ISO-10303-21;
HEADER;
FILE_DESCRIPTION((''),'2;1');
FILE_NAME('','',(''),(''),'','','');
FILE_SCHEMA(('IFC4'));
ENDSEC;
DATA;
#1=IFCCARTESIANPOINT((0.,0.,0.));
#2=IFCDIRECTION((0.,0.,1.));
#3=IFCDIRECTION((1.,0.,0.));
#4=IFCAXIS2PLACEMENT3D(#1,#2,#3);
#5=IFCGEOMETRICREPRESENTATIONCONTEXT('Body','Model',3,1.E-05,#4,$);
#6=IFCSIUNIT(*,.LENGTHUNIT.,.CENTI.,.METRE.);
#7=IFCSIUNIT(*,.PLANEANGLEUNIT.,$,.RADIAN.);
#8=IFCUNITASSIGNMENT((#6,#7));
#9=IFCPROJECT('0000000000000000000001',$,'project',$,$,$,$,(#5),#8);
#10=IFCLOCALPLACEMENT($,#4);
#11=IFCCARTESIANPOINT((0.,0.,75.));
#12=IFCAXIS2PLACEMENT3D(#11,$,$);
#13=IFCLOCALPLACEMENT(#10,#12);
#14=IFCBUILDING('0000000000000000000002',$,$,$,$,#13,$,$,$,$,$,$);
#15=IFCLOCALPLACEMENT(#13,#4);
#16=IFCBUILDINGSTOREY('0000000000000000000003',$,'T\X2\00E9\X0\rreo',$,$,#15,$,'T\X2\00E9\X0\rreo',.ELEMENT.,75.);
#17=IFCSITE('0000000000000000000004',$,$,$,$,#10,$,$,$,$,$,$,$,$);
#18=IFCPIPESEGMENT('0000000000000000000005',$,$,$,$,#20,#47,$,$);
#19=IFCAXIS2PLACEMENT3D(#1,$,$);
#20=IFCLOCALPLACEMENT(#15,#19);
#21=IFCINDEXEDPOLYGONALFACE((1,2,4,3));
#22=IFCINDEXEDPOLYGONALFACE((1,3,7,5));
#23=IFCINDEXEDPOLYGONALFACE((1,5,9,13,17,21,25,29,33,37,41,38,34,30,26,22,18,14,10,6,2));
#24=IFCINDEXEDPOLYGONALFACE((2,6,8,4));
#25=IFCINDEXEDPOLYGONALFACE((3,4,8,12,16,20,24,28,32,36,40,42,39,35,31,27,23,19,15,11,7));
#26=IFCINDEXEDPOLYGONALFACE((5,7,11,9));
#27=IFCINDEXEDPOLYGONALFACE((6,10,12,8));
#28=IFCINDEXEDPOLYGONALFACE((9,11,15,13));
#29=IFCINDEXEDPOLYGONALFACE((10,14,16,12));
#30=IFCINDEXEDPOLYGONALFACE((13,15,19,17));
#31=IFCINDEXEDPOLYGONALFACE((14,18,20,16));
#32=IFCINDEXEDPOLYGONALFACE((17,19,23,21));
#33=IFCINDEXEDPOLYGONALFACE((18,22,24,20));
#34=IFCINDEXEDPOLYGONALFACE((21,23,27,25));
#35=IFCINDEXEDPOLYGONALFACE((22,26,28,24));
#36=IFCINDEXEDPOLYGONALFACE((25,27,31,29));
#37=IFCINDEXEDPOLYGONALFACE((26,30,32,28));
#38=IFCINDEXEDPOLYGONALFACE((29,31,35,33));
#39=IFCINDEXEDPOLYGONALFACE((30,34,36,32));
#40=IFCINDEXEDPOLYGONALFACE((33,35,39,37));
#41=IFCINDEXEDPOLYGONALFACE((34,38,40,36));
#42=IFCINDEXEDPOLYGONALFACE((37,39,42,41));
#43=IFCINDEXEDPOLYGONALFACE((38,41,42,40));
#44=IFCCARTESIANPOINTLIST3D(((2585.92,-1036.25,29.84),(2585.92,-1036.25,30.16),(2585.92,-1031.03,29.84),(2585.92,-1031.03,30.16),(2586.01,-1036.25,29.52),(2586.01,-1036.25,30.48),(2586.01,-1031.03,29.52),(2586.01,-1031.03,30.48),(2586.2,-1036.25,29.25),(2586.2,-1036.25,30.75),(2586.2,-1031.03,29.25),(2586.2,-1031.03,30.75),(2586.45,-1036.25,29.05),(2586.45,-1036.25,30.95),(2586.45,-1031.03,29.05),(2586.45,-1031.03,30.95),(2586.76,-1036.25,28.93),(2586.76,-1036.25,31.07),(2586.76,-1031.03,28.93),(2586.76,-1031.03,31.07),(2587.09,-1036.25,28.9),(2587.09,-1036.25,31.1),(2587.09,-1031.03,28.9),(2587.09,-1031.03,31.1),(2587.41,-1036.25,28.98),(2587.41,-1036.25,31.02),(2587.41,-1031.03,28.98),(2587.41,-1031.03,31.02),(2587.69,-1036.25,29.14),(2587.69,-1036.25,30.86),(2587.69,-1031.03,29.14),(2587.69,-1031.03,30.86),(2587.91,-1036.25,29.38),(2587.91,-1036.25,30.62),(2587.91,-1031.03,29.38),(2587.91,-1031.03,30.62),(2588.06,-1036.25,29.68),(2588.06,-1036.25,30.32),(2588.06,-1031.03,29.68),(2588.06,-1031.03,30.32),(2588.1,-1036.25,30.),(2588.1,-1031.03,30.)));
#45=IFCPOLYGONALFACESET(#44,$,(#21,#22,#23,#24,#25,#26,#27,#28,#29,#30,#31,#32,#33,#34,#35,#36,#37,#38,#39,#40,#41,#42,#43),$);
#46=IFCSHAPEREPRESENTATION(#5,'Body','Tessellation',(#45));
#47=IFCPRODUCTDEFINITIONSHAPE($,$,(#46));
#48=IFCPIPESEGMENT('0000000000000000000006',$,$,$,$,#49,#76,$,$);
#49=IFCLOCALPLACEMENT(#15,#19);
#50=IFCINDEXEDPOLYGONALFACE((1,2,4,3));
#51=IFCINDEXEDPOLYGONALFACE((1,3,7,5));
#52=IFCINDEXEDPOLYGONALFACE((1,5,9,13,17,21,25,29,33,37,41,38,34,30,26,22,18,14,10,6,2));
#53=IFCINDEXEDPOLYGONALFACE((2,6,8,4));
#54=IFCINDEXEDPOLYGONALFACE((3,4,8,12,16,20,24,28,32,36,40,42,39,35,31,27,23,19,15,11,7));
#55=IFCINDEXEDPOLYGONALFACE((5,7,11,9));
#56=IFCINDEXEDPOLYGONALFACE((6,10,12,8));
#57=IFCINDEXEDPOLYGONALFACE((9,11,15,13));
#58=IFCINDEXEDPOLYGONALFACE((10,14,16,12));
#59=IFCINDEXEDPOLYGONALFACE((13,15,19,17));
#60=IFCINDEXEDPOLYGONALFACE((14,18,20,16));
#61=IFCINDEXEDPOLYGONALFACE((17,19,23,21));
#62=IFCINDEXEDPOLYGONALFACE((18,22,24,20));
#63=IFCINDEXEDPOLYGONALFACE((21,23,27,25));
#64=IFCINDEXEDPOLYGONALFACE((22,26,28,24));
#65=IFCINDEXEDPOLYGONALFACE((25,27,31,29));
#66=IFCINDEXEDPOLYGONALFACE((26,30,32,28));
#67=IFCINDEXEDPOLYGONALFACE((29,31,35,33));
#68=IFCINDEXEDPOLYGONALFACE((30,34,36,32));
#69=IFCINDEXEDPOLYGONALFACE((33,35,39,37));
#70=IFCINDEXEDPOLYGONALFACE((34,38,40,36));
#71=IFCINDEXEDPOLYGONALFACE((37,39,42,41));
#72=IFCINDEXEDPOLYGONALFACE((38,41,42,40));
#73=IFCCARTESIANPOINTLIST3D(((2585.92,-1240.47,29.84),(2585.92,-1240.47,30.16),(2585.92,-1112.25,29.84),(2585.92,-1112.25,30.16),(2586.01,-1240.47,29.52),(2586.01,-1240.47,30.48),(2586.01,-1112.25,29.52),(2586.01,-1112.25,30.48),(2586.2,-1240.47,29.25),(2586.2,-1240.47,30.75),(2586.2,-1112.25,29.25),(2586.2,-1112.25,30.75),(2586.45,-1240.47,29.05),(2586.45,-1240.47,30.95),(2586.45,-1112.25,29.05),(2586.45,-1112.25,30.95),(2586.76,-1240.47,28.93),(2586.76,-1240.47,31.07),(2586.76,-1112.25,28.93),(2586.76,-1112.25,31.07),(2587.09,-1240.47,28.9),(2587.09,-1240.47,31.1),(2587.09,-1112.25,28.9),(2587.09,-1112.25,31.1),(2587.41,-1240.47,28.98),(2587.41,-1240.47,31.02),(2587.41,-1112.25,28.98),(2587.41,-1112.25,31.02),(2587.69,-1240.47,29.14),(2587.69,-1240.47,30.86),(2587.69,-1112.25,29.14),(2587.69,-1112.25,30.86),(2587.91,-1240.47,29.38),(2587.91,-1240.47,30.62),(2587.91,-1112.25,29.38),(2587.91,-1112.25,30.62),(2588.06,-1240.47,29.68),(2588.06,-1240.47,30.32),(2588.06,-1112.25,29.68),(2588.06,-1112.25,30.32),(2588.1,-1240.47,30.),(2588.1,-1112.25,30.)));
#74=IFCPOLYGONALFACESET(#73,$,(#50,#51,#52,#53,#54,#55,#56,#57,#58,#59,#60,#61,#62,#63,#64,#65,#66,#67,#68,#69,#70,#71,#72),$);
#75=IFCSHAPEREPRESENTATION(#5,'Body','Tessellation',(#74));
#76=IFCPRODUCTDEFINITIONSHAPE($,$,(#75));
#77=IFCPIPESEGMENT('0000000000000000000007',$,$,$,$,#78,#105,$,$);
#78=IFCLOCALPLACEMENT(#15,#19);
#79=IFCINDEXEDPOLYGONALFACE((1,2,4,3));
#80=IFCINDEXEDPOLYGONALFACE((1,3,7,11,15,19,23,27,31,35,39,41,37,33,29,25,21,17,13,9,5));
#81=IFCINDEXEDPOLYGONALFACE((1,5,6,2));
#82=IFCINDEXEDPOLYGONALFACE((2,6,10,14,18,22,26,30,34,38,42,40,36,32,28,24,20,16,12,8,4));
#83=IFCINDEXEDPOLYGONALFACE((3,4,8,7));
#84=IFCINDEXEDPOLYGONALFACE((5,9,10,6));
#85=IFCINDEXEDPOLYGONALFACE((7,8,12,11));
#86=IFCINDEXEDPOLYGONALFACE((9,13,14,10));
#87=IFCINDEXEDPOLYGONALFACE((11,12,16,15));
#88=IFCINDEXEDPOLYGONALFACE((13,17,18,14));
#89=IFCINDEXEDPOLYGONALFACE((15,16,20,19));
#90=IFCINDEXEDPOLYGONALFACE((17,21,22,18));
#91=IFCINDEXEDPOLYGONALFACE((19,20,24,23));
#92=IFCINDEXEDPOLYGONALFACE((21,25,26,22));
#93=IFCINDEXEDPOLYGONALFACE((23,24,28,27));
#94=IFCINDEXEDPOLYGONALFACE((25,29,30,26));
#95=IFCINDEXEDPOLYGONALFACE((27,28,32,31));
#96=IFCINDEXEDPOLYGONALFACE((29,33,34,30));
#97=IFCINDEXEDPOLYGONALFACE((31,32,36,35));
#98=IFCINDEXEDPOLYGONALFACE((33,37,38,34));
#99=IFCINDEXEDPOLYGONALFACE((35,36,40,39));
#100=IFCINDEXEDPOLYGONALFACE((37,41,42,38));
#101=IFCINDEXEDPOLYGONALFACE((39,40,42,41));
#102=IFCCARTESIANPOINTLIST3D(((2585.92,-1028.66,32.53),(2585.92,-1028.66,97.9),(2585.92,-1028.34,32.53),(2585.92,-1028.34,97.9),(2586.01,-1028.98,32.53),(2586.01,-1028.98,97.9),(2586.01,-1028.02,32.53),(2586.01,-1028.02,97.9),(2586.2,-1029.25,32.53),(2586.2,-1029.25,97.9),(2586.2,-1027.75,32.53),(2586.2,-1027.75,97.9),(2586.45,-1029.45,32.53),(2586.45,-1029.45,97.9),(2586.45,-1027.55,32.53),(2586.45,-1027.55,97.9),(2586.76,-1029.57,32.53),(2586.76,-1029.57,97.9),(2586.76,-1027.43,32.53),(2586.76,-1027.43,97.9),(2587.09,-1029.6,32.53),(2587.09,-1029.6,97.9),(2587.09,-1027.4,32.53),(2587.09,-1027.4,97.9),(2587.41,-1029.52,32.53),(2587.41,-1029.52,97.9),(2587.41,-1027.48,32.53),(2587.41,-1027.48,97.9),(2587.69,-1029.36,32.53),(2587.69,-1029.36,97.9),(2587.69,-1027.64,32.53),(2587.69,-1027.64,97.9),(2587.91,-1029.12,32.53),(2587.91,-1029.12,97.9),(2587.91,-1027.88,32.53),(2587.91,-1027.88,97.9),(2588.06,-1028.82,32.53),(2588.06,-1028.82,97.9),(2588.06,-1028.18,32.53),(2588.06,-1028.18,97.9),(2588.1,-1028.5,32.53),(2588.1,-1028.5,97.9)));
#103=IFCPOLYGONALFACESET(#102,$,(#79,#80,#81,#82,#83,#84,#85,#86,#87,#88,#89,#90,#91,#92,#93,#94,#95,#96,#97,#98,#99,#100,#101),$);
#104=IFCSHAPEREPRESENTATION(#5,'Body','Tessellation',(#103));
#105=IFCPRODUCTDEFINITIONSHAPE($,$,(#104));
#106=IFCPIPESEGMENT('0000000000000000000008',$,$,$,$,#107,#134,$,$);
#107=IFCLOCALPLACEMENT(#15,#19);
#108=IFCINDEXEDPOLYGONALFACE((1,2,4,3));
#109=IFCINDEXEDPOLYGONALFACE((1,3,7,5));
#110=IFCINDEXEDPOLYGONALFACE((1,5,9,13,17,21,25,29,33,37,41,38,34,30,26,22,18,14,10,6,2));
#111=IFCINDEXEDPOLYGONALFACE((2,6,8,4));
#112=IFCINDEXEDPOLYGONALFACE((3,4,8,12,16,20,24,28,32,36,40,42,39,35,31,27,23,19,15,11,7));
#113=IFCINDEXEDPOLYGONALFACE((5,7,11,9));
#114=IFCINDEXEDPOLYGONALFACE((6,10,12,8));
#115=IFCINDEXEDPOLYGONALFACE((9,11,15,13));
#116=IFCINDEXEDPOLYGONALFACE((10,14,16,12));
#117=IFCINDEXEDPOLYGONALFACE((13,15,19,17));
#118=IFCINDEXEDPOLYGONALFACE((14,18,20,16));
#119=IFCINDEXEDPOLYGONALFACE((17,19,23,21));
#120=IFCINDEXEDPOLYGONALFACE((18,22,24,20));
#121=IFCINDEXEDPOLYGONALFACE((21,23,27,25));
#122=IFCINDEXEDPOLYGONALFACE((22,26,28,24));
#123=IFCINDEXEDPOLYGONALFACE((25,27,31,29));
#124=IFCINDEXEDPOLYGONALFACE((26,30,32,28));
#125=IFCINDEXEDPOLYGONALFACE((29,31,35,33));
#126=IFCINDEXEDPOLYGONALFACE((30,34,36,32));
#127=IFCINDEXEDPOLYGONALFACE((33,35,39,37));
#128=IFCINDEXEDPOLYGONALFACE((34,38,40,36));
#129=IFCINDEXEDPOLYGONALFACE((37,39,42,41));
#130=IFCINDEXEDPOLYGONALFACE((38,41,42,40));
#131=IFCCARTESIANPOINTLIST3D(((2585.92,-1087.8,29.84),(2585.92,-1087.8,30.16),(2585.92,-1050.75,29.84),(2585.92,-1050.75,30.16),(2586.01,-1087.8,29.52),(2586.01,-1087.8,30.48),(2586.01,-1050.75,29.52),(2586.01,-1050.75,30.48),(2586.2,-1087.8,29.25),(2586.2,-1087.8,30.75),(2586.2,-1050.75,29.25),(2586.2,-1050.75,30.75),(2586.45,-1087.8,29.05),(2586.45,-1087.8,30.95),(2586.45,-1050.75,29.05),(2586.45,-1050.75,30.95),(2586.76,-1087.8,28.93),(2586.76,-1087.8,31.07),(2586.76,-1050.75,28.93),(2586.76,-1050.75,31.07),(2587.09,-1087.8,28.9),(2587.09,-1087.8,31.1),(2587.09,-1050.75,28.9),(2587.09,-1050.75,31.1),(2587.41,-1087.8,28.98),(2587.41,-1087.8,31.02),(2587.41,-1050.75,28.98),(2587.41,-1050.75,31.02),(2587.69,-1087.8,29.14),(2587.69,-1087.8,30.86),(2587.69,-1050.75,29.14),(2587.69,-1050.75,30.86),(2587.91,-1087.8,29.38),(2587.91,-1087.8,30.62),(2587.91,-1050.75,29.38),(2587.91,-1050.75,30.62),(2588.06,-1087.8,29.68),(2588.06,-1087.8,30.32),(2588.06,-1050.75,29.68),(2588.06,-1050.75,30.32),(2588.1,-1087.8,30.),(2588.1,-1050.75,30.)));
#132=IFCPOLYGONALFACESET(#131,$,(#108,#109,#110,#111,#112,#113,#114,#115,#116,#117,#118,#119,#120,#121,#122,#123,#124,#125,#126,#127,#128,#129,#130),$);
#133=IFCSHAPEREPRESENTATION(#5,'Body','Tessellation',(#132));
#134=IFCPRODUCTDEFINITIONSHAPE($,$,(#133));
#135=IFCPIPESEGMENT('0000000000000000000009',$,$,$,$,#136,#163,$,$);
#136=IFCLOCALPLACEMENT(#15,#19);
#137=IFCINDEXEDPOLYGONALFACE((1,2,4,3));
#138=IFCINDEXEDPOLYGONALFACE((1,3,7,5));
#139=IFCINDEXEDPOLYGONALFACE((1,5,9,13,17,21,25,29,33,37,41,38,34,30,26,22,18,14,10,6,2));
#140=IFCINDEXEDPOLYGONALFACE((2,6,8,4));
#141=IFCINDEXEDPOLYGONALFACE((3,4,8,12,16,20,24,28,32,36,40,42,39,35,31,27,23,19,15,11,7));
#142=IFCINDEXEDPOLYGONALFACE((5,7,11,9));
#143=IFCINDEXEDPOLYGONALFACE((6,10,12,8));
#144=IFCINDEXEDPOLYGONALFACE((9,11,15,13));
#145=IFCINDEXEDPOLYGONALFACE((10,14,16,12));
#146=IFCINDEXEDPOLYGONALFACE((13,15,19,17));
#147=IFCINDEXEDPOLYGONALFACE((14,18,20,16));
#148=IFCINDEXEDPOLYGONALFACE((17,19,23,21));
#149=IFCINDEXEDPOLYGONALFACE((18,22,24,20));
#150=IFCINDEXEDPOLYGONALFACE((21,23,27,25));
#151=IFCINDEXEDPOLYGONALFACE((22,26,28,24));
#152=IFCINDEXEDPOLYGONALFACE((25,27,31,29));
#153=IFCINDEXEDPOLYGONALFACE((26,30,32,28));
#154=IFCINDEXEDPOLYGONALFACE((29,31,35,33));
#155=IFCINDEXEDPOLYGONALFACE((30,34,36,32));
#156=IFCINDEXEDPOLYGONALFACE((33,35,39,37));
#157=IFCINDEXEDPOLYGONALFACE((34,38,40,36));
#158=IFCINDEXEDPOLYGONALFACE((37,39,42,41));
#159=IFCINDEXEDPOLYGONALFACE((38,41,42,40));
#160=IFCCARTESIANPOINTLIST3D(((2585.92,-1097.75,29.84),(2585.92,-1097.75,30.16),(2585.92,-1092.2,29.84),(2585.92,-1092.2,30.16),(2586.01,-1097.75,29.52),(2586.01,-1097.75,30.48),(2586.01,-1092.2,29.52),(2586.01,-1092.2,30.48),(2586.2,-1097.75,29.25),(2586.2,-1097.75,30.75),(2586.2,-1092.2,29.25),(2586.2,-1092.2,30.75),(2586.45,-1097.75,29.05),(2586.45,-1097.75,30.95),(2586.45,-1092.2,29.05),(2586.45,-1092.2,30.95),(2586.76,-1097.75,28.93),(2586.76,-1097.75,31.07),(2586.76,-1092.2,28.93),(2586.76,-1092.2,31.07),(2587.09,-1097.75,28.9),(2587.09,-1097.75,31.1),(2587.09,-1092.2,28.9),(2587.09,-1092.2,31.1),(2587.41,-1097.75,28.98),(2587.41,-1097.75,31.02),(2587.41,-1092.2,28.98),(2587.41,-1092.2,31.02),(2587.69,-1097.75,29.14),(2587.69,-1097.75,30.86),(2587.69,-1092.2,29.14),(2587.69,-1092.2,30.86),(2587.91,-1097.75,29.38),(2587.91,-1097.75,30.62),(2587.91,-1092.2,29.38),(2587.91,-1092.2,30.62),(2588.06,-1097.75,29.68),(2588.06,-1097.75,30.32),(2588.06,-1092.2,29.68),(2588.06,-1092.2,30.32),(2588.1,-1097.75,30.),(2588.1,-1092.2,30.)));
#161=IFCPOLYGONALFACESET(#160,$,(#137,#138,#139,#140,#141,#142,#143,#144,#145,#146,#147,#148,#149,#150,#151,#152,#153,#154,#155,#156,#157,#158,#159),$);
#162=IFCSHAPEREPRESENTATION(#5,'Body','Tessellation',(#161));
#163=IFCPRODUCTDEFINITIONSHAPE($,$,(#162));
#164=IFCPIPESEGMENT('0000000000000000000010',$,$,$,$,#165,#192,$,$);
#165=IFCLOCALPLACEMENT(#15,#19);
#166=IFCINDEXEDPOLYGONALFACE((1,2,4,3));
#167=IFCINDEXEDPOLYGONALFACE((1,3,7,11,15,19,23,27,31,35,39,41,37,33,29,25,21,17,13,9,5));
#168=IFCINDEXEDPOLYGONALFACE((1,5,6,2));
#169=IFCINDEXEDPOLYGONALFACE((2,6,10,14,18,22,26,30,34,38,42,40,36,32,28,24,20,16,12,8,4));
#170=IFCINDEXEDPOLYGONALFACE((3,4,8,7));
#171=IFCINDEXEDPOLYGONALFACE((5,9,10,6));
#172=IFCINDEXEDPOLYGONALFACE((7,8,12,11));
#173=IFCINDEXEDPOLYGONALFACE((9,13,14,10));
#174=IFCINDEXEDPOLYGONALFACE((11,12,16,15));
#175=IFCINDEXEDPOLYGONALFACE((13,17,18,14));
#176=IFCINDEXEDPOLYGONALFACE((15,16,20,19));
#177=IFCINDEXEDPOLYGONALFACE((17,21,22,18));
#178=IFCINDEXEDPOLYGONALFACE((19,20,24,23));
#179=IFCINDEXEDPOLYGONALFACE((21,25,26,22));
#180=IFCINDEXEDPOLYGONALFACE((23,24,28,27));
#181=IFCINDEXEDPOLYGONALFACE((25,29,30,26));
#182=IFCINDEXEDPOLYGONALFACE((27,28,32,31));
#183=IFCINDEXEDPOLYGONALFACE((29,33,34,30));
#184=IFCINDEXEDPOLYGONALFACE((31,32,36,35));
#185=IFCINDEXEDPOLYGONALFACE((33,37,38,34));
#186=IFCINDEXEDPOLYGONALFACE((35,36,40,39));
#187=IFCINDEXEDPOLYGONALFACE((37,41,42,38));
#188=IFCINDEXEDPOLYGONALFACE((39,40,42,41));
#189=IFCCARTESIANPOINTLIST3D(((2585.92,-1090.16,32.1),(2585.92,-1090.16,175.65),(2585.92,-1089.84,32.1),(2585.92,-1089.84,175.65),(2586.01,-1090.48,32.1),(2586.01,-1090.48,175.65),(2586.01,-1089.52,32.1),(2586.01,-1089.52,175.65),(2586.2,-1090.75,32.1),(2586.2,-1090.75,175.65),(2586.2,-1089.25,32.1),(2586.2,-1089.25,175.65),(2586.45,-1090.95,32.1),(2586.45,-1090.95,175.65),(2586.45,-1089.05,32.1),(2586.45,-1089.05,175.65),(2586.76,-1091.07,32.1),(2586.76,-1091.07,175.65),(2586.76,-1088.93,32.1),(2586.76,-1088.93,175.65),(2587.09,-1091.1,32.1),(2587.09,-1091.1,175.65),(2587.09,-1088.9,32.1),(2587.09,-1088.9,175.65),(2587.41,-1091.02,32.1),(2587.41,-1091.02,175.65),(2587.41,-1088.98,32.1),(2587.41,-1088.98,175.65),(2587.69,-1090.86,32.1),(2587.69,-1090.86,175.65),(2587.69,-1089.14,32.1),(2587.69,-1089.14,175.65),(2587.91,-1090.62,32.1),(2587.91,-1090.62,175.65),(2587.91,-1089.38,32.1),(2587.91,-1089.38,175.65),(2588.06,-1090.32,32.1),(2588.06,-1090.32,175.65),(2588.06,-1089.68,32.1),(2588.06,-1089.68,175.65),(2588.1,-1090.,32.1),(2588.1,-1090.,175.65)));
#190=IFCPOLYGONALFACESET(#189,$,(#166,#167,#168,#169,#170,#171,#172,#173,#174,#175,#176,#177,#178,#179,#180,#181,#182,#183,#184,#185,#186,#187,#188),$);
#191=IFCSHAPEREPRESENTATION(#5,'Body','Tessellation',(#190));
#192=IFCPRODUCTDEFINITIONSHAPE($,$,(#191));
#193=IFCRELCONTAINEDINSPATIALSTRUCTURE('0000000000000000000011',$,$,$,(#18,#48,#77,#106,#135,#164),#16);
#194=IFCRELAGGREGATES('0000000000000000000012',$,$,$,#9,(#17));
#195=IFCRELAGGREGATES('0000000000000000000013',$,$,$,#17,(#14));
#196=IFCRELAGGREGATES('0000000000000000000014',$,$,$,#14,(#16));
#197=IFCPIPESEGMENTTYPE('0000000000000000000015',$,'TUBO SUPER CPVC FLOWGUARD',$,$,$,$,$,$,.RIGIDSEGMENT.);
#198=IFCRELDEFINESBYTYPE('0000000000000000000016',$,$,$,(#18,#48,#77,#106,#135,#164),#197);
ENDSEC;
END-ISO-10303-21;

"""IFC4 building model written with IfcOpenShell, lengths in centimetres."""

from ifc_helpers import new_model, si_unit, frame, origin_with_axes, origin_2d_with_axis, place, context, project, spatial, circle, extrude, type_object, element, save


model = new_model("IFC4")

# Units and contexts
model_context = context("Model", 3, precision=1e-05, world=origin_with_axes(), identifier="Body")
ifc_project = project(units=[si_unit("LENGTHUNIT", "METRE", prefix="CENTI"), si_unit("PLANEANGLEUNIT", "RADIAN")], contexts=[model_context])

# Site, building, storey
site_placement = place(None, origin_with_axes())
site = spatial("IfcSite", under=ifc_project, at=site_placement)
building_placement = place(site_placement, frame((0.0, 0.0, 75.0)))
building = spatial("IfcBuilding", under=site, at=building_placement)
storey_placement = place(building_placement, origin_with_axes())
storey = spatial("IfcBuildingStorey", under=building, at=storey_placement, Name="Térreo", LongName="Térreo", CompositionType="ELEMENT", Elevation=75.0)

# Pipe segments
pipe_segment_type_1 = type_object("IfcPipeSegmentType", Name="TUBO SUPER CPVC FLOWGUARD", PredefinedType="RIGIDSEGMENT")
pipe_segment_1_placement = place(storey_placement, frame((2587.0, -1033.64, 31.1), z_axis=(0.0, 0.0, 1.0), x_axis=(1.0, 0.0, 0.0)))
element("IfcPipeSegment", 1, at=pipe_segment_1_placement, inside=storey, type_object=pipe_segment_type_1, context=model_context, shape_type="SolidModel", body=[
    extrude(circle(Radius=1.1, at=origin_2d_with_axis()), frame((0.0, -2.61, -1.1), z_axis=(0.0, 1.0, 0.0), x_axis=(1.0, 0.0, 0.0)), (0.0, 0.0, 1.0), 5.22),
])
pipe_segment_2_placement = place(storey_placement, frame((2587.0, -1176.36, 31.1), z_axis=(0.0, 0.0, 1.0), x_axis=(1.0, 0.0, 0.0)))
element("IfcPipeSegment", 2, at=pipe_segment_2_placement, inside=storey, type_object=pipe_segment_type_1, context=model_context, shape_type="SolidModel", body=[
    extrude(circle(Radius=1.1, at=origin_2d_with_axis()), frame((0.0, 64.11, -1.1), z_axis=(0.0, -1.0, 0.0), x_axis=(1.0, 0.0, 0.0)), (0.0, 0.0, 1.0), 128.22),
])
pipe_segment_3_placement = place(storey_placement, frame((2587.0, -1028.5, 97.9), z_axis=(0.0, 0.0, 1.0), x_axis=(1.0, 0.0, 0.0)))
element("IfcPipeSegment", 3, at=pipe_segment_3_placement, inside=storey, type_object=pipe_segment_type_1, context=model_context, shape_type="SolidModel", body=[
    extrude(circle(Radius=1.1, at=origin_2d_with_axis()), frame((0.0, 0.0, -65.37), z_axis=(0.0, 0.0, 1.0), x_axis=(1.0, 0.0, 0.0)), (0.0, 0.0, 1.0), 65.37),
])
pipe_segment_4_placement = place(storey_placement, frame((2587.0, -1069.27, 31.1), z_axis=(0.0, 0.0, 1.0), x_axis=(1.0, 0.0, 0.0)))
element("IfcPipeSegment", 4, at=pipe_segment_4_placement, inside=storey, type_object=pipe_segment_type_1, context=model_context, shape_type="SolidModel", body=[
    extrude(circle(Radius=1.1, at=origin_2d_with_axis()), frame((0.0, -18.52, -1.1), z_axis=(0.0, 1.0, 0.0), x_axis=(1.0, 0.0, 0.0)), (0.0, 0.0, 1.0), 37.05),
])
pipe_segment_5_placement = place(storey_placement, frame((2587.0, -1094.97, 31.1), z_axis=(0.0, 0.0, 1.0), x_axis=(1.0, 0.0, 0.0)))
element("IfcPipeSegment", 5, at=pipe_segment_5_placement, inside=storey, type_object=pipe_segment_type_1, context=model_context, shape_type="SolidModel", body=[
    extrude(circle(Radius=1.1, at=origin_2d_with_axis()), frame((0.0, 2.77, -1.1), z_axis=(0.0, -1.0, 0.0), x_axis=(1.0, 0.0, 0.0)), (0.0, 0.0, 1.0), 5.55),
])
pipe_segment_6_placement = place(storey_placement, frame((2587.0, -1090.0, 175.65), z_axis=(0.0, 0.0, 1.0), x_axis=(1.0, 0.0, 0.0)))
element("IfcPipeSegment", 6, at=pipe_segment_6_placement, inside=storey, type_object=pipe_segment_type_1, context=model_context, shape_type="SolidModel", body=[
    extrude(circle(Radius=1.1, at=origin_2d_with_axis()), frame((0.0, 0.0, 0.0), z_axis=(0.0, 0.0, -1.0), x_axis=(1.0, 0.0, 0.0)), (0.0, 0.0, 1.0), 143.55),
])

save(model, "model.ifc")
